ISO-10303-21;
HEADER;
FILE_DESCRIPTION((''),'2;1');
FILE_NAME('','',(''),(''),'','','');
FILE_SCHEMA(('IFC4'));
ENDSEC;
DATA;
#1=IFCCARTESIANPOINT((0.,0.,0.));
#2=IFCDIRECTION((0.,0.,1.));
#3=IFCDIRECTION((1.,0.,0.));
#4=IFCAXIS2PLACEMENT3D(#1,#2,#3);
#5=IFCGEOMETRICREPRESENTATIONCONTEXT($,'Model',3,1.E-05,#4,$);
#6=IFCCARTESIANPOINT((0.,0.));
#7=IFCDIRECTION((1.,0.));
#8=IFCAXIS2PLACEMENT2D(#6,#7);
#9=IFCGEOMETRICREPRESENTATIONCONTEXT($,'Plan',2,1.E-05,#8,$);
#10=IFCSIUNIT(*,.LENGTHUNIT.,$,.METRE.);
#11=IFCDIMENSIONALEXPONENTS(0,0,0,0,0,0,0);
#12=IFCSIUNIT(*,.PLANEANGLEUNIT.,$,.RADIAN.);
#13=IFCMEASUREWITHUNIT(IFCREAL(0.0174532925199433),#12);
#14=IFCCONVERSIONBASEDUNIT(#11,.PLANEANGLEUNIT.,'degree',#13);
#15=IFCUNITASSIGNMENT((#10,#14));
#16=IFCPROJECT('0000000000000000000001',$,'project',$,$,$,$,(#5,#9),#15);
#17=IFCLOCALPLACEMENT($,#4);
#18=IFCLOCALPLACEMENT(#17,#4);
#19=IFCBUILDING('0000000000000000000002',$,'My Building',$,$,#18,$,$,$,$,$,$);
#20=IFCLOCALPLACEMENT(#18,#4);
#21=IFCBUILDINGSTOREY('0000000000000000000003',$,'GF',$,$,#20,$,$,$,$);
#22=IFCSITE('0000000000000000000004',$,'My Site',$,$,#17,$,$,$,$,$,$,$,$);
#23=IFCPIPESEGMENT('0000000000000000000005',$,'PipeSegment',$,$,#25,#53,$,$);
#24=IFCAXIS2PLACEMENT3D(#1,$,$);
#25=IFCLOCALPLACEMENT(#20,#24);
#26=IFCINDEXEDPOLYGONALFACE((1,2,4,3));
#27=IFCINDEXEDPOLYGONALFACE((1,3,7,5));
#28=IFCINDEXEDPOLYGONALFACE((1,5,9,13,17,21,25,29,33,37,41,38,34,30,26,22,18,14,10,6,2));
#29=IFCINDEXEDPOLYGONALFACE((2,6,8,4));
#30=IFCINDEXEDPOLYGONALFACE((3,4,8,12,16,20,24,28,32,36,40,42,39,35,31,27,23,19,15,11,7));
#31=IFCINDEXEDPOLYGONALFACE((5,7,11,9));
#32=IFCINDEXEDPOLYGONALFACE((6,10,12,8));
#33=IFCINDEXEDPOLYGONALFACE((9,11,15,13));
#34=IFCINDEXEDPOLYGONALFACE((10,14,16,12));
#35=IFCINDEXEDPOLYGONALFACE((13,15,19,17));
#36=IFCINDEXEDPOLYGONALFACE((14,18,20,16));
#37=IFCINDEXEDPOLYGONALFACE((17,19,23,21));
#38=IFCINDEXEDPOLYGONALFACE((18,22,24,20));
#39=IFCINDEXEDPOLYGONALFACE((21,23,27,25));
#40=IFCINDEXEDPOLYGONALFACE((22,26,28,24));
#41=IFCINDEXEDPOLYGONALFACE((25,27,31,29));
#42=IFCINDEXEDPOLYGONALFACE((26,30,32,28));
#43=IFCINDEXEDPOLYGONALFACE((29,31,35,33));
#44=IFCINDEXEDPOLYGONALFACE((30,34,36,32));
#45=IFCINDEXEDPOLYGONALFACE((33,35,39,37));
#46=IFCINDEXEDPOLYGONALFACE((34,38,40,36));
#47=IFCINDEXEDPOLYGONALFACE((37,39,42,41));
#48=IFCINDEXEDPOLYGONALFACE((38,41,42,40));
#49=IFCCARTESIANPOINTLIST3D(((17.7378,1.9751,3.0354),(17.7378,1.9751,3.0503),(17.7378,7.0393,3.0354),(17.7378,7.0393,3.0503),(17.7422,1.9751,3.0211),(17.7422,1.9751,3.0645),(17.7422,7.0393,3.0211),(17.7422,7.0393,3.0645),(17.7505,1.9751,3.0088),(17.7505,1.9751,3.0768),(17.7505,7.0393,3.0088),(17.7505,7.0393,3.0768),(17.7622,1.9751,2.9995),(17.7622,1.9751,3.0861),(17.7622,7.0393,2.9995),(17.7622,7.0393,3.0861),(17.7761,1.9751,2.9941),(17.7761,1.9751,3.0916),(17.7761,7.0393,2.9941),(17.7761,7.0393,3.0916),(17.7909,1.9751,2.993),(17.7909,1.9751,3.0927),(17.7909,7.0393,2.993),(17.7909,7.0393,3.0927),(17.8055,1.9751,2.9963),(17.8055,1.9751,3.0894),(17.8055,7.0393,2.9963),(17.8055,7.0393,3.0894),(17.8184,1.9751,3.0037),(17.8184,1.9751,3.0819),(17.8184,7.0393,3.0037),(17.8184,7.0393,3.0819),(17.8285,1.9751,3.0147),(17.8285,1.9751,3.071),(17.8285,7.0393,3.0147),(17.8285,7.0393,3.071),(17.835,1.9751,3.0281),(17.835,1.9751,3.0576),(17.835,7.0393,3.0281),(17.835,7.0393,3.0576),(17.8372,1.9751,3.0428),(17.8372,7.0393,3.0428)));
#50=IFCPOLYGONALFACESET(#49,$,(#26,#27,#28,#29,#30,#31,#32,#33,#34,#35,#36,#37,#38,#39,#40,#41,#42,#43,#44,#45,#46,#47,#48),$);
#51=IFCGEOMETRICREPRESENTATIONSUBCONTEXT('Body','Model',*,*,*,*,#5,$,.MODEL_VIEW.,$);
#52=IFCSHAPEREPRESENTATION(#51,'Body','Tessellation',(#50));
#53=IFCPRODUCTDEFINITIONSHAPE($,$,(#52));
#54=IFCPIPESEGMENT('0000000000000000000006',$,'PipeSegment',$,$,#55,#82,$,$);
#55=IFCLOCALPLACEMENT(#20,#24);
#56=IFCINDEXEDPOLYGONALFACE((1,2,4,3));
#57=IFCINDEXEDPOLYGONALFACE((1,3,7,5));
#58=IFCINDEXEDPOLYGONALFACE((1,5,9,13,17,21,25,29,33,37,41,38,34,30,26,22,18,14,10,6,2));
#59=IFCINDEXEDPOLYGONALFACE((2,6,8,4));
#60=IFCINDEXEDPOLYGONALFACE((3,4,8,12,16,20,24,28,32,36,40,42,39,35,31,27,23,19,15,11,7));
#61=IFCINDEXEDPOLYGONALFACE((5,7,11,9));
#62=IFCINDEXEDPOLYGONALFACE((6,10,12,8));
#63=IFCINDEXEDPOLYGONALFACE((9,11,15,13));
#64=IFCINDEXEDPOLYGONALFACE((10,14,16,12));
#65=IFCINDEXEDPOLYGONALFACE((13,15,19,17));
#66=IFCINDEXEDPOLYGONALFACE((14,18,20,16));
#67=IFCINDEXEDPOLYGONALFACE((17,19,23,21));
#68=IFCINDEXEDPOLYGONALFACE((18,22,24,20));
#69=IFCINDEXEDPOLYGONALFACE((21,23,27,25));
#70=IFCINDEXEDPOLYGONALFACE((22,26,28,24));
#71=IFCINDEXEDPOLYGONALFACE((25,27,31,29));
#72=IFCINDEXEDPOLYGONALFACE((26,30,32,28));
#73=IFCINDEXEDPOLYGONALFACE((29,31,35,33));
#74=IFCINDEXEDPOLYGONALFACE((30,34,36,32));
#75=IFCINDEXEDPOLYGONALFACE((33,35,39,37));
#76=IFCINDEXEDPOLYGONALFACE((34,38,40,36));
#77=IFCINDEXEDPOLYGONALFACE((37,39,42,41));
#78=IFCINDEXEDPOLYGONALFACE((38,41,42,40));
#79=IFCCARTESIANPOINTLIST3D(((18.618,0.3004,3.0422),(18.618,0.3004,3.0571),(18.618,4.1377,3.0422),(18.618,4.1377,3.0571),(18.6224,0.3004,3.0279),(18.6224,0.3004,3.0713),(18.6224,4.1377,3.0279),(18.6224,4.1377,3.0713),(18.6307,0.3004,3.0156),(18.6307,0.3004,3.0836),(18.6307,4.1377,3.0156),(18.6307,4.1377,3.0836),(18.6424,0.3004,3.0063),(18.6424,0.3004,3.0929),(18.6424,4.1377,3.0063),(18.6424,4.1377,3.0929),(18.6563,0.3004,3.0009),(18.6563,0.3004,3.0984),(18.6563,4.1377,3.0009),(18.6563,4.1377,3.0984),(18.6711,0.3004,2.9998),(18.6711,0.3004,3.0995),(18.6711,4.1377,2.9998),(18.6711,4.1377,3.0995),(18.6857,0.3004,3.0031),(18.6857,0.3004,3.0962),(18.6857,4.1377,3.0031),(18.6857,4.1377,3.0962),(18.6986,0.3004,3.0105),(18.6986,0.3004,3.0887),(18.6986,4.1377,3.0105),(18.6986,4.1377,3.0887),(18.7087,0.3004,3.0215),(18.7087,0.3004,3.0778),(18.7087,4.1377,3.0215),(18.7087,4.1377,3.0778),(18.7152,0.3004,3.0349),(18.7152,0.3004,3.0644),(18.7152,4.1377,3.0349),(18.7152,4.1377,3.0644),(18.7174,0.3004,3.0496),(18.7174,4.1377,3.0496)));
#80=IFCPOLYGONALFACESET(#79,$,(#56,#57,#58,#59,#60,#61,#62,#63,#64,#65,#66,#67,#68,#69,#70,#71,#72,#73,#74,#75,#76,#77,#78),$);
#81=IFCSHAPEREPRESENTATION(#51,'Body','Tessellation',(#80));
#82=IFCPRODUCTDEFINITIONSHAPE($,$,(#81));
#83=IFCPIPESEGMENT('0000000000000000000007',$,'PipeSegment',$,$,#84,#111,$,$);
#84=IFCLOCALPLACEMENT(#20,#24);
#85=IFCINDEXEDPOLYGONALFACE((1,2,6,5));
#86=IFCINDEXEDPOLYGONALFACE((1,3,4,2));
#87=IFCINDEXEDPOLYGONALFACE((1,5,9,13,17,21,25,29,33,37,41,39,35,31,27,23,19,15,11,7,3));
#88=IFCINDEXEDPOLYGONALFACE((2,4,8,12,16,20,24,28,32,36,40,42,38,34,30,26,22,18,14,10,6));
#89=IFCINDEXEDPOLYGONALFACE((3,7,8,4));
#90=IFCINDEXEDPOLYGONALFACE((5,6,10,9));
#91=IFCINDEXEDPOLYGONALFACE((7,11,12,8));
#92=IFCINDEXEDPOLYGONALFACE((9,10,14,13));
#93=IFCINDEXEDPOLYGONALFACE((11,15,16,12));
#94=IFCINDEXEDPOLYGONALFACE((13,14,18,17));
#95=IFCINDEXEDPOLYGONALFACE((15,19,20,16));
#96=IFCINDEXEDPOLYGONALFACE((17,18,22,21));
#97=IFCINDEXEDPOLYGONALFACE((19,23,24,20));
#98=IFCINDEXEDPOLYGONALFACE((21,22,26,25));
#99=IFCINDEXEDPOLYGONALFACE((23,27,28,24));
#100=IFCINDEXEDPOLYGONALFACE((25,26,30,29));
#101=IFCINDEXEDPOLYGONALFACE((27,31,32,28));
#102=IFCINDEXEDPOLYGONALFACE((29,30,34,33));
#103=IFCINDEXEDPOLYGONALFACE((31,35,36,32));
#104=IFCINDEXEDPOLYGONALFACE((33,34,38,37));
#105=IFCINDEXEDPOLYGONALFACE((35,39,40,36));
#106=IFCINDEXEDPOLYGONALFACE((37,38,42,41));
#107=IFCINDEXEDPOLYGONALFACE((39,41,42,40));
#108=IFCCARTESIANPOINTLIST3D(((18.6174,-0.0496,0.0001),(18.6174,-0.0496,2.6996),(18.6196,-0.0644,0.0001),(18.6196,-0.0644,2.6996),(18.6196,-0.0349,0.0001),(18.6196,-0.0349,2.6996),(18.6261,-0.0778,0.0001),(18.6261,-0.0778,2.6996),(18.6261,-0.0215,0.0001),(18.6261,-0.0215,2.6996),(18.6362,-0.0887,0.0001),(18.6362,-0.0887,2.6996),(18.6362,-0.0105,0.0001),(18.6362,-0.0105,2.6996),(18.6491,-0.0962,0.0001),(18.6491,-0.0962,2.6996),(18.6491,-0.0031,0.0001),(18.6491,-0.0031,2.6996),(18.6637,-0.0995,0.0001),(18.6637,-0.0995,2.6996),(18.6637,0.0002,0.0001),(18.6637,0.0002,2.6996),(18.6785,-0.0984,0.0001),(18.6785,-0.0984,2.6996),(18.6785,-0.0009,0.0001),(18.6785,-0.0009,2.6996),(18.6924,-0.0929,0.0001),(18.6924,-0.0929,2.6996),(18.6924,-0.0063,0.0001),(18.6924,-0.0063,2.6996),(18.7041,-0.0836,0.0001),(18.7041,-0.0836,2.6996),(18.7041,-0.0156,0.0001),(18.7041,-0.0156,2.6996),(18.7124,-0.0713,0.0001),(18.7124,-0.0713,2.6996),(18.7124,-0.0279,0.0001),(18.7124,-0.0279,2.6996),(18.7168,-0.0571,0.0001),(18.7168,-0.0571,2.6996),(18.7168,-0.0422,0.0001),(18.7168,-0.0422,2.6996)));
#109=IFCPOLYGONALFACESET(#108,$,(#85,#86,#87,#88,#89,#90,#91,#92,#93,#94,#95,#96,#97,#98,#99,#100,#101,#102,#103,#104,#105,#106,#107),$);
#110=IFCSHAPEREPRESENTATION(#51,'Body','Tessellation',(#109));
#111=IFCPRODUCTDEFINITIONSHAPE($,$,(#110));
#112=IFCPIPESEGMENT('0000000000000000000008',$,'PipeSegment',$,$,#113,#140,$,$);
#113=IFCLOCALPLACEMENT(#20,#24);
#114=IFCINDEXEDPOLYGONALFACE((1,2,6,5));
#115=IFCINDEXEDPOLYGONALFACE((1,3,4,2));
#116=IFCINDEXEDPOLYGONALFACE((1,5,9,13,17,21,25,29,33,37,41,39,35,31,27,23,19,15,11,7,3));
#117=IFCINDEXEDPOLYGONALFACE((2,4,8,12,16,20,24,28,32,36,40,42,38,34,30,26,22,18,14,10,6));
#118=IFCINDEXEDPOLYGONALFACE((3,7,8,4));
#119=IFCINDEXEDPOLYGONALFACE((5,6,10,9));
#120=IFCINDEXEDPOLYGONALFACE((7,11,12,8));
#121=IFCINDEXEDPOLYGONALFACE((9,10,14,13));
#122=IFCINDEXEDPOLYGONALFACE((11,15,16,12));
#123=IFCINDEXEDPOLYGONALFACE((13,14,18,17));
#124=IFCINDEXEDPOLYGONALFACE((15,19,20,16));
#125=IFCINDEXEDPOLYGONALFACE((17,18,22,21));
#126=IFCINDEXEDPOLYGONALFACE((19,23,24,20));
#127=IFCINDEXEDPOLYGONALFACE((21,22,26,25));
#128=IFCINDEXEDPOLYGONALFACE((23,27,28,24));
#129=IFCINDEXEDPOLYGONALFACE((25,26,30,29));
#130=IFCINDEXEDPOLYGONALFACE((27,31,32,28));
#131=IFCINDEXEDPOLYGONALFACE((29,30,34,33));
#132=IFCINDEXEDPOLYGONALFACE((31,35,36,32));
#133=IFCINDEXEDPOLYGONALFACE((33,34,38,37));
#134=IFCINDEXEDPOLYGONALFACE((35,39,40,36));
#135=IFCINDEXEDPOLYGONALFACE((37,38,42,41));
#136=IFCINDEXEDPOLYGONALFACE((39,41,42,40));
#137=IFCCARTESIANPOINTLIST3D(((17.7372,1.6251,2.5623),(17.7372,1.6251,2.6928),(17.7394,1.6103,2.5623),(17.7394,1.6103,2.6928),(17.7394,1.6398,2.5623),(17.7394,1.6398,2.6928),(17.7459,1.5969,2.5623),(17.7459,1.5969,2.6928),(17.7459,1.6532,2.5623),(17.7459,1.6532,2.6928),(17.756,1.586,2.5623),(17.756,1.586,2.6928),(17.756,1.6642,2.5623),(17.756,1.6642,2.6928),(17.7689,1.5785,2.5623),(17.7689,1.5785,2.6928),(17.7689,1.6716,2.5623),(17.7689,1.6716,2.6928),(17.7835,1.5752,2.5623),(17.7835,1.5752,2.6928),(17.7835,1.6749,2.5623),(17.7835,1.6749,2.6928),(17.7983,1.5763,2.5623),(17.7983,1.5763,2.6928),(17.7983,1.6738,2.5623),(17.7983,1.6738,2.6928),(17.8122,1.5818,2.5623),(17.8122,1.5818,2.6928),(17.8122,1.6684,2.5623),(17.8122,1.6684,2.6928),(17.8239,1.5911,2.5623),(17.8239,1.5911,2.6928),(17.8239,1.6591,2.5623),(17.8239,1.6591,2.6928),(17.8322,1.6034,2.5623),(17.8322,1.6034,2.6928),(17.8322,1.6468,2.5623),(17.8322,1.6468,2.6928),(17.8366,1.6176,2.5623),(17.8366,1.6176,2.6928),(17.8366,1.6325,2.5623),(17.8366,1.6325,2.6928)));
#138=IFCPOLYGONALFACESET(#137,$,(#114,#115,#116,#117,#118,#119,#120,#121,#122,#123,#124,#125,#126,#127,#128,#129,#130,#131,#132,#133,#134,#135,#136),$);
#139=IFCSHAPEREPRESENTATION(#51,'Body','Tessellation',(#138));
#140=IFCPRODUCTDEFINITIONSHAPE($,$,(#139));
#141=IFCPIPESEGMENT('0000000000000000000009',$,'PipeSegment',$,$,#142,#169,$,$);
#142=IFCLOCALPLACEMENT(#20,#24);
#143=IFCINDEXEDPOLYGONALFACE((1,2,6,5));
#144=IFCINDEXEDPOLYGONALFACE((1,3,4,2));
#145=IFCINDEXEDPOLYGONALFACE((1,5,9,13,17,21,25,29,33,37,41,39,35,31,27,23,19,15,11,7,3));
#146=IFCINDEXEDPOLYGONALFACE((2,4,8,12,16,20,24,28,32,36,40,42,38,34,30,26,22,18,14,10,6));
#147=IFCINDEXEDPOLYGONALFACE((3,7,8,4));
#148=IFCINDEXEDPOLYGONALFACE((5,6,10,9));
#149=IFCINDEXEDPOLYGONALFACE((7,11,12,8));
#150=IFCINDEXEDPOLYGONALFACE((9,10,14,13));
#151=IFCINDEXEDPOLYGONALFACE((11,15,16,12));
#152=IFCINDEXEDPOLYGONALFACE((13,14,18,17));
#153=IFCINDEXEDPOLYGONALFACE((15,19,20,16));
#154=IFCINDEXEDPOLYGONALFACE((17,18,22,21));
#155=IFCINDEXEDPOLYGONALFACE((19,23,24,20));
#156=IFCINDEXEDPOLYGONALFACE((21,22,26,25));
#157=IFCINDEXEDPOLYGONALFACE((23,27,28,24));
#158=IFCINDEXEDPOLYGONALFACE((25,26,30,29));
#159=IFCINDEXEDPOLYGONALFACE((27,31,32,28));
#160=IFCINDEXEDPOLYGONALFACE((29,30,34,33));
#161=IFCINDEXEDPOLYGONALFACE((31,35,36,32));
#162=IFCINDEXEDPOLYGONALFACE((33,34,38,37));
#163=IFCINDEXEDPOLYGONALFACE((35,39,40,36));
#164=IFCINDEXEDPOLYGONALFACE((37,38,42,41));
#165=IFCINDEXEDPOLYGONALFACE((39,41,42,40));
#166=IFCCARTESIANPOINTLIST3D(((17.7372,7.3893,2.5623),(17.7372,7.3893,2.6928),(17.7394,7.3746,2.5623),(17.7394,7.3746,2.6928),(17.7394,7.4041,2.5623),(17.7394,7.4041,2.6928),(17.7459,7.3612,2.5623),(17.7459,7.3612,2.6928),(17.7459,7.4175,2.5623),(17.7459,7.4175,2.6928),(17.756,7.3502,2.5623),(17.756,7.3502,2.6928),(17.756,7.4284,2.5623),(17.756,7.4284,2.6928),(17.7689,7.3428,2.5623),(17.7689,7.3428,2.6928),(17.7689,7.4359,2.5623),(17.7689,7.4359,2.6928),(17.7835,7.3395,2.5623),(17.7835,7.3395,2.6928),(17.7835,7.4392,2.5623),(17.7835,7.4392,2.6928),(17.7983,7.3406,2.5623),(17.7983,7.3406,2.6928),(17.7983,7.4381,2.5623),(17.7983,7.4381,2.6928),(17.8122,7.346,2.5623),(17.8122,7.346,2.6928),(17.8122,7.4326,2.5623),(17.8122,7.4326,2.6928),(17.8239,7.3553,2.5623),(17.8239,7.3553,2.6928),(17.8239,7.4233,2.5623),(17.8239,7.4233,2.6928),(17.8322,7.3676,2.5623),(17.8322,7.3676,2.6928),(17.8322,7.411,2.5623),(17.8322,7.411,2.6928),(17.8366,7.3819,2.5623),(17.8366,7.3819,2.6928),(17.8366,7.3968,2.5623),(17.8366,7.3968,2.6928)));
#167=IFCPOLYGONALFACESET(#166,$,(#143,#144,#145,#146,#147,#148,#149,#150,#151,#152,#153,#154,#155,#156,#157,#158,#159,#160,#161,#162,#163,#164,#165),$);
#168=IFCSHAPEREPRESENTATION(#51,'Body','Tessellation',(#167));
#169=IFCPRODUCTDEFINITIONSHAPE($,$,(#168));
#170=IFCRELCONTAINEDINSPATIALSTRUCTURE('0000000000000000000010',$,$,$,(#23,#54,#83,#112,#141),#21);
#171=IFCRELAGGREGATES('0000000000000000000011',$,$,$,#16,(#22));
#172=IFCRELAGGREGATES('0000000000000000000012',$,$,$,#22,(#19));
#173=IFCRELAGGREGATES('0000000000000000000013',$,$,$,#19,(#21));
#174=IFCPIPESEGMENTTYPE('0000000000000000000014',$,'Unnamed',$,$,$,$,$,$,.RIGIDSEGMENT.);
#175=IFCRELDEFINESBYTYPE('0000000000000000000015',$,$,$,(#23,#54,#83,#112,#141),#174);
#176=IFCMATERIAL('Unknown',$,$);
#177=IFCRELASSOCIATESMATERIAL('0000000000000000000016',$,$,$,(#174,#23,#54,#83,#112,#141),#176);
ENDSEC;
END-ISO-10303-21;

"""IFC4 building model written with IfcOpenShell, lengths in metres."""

from ifc_helpers import new_model, entity, si_unit, converted_unit, frame, origin_with_axes, origin_2d_with_axis, place, context, subcontext, project, spatial, circle, extrude, material, material_profile, profile_set, profile_usage, type_object, element, save


model = new_model("IFC4")

# Units and contexts
model_context = context("Model", 3, precision=1e-05, world=origin_with_axes())
plan_context = context("Plan", 2, precision=1e-05, world=origin_2d_with_axis())
body_context_1 = subcontext(model_context, "Body", "Model", "MODEL_VIEW")
ifc_project = project(units=[si_unit("LENGTHUNIT", "METRE"), converted_unit("PLANEANGLEUNIT", "degree", entity("IfcReal", 0.0174532925199433), si_unit("PLANEANGLEUNIT", "RADIAN"), dimensions=[0, 0, 0, 0, 0, 0, 0])], contexts=[model_context, plan_context])

# Site, building, storey
site_placement = place(None, origin_with_axes())
site = spatial("IfcSite", under=ifc_project, at=site_placement, Name="My Site")
building_placement = place(site_placement, origin_with_axes())
building = spatial("IfcBuilding", under=site, at=building_placement, Name="My Building")
storey_placement = place(building_placement, origin_with_axes())
storey = spatial("IfcBuildingStorey", under=building, at=storey_placement, Name="GF")

# Shared definitions
ifc_material = material(Name="Unknown")

# Pipe segments
ifc_material_profile = material_profile(ifc_material, circle(Radius=0.05))
ifc_profile_set = profile_set([ifc_material_profile])
ifc_profile_usage_1 = profile_usage(ifc_profile_set, cardinal=5)
pipe_segment_type = type_object("IfcPipeSegmentType", Name="Unnamed", PredefinedType="RIGIDSEGMENT", material=ifc_profile_set)
pipe_segment_1_placement = place(storey_placement, frame((17.7872, 7.0393, 3.0428), z_axis=(0.0, -1.0, 0.0), x_axis=(1.0, 0.0, 0.0)))
element("IfcPipeSegment", 1, at=pipe_segment_1_placement, inside=storey, type_object=pipe_segment_type, material=ifc_profile_usage_1, Name="PipeSegment", context=body_context_1, shape_type="SweptSolid", body=[
    extrude(circle(Radius=0.05), origin_with_axes(), (0.0, 0.0, 1.0), 5.0643),
])
ifc_profile_usage_2 = profile_usage(ifc_profile_set, cardinal=5)
pipe_segment_2_placement = place(storey_placement, frame((18.6674, 4.1377, 3.0496), z_axis=(0.0, -1.0, 0.0), x_axis=(1.0, 0.0, 0.0)))
element("IfcPipeSegment", 2, at=pipe_segment_2_placement, inside=storey, type_object=pipe_segment_type, material=ifc_profile_usage_2, Name="PipeSegment", context=body_context_1, shape_type="SweptSolid", body=[
    extrude(circle(Radius=0.05), origin_with_axes(), (0.0, 0.0, 1.0), 3.8374),
])
ifc_profile_usage_3 = profile_usage(ifc_profile_set, cardinal=5)
pipe_segment_3_placement = place(storey_placement, frame((18.6674, -0.0496, 2.6996), z_axis=(0.0, 0.0, -1.0), x_axis=(-1.0, 0.0, 0.0)))
element("IfcPipeSegment", 3, at=pipe_segment_3_placement, inside=storey, type_object=pipe_segment_type, material=ifc_profile_usage_3, Name="PipeSegment", context=body_context_1, shape_type="SweptSolid", body=[
    extrude(circle(Radius=0.05), origin_with_axes(), (0.0, 0.0, 1.0), 2.6996),
])
ifc_profile_usage_4 = profile_usage(ifc_profile_set, cardinal=5)
pipe_segment_4_placement = place(storey_placement, frame((17.7872, 1.6251, 2.6928), z_axis=(0.0, 0.0, -1.0), x_axis=(-1.0, 0.0, 0.0)))
element("IfcPipeSegment", 4, at=pipe_segment_4_placement, inside=storey, type_object=pipe_segment_type, material=ifc_profile_usage_4, Name="PipeSegment", context=body_context_1, shape_type="SweptSolid", body=[
    extrude(circle(Radius=0.05), origin_with_axes(), (0.0, 0.0, 1.0), 0.1306),
])
ifc_profile_usage_5 = profile_usage(ifc_profile_set, cardinal=5)
pipe_segment_5_placement = place(storey_placement, frame((17.7872, 7.3893, 2.6928), z_axis=(0.0, 0.0, -1.0), x_axis=(-1.0, 0.0, 0.0)))
element("IfcPipeSegment", 5, at=pipe_segment_5_placement, inside=storey, type_object=pipe_segment_type, material=ifc_profile_usage_5, Name="PipeSegment", context=body_context_1, shape_type="SweptSolid", body=[
    extrude(circle(Radius=0.05), origin_with_axes(), (0.0, 0.0, 1.0), 0.1306),
])

save(model, "model.ifc")
